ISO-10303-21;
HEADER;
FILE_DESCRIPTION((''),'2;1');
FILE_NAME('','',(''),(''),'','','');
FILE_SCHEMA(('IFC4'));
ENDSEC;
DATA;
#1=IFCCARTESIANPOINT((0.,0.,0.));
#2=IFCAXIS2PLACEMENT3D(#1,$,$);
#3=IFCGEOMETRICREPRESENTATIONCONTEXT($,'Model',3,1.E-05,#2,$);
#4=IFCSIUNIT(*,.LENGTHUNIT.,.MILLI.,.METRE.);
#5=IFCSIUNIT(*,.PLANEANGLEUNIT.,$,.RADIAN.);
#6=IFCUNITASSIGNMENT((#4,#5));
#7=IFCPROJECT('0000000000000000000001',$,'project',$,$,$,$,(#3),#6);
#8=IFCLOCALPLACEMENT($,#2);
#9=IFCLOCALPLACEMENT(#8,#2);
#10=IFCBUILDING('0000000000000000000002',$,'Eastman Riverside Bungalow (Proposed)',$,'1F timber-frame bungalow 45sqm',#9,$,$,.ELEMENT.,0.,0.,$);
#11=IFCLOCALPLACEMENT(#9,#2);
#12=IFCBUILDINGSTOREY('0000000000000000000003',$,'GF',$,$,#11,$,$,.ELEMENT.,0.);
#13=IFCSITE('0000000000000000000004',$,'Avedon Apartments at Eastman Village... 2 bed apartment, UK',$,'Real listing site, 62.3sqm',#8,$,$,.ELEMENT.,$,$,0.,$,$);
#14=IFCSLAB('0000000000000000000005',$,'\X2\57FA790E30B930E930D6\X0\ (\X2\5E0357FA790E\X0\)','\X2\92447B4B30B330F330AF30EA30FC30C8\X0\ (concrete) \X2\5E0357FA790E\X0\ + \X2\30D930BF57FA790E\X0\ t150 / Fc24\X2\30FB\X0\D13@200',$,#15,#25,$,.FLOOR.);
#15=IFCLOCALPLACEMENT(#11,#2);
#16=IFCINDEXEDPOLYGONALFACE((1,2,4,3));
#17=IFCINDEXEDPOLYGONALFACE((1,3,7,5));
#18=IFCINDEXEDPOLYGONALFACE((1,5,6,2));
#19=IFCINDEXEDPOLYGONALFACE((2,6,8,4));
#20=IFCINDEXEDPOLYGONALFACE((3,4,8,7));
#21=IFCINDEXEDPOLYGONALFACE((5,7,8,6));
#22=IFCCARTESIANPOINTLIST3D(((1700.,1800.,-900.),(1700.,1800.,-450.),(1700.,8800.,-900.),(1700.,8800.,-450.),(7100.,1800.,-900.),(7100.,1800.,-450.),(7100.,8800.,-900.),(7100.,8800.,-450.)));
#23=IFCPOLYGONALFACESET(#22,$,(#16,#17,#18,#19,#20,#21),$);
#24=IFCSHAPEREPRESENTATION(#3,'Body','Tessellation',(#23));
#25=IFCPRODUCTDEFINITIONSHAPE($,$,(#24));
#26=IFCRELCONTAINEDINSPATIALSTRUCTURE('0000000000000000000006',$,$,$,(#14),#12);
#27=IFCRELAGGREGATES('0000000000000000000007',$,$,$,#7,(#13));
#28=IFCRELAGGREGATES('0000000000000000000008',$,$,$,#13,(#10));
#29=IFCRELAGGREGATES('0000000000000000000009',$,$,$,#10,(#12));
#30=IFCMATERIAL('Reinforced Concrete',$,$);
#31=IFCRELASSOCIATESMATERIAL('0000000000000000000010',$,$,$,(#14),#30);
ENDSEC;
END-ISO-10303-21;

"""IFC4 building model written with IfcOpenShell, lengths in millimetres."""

from ifc_helpers import new_model, si_unit, frame, frame_2d, origin, place, context, project, spatial, rectangle, extrude, material, element, save


model = new_model("IFC4")

# Units and contexts
model_context = context("Model", 3, precision=1e-05, world=origin())
ifc_project = project(units=[si_unit("LENGTHUNIT", "METRE", prefix="MILLI"), si_unit("PLANEANGLEUNIT", "RADIAN")], contexts=[model_context])

# Site, building, storey
site_placement = place(None, origin())
site = spatial("IfcSite", under=ifc_project, at=site_placement, Name="Avedon Apartments at Eastman Village... 2 bed apartment, UK", ObjectType="Real listing site, 62.3sqm", CompositionType="ELEMENT", RefElevation=0.0)
building_placement = place(site_placement, origin())
building = spatial("IfcBuilding", under=site, at=building_placement, Name="Eastman Riverside Bungalow (Proposed)", ObjectType="1F timber-frame bungalow 45sqm", CompositionType="ELEMENT", ElevationOfRefHeight=0.0, ElevationOfTerrain=0.0)
storey_placement = place(building_placement, origin())
storey = spatial("IfcBuildingStorey", under=building, at=storey_placement, Name="GF", CompositionType="ELEMENT", Elevation=0.0)

# Slab
ifc_material_1 = material(Name="Reinforced Concrete")
slab_1_placement = place(storey_placement, frame((850.0, 900.0, -450.0)))
element("IfcSlab", 1, at=slab_1_placement, inside=storey, material=ifc_material_1, Name="基礎スラブ (布基礎)", Description="鉄筋コンクリート (concrete) 布基礎 + ベタ基礎 t150 / Fc24・D13@200", PredefinedType="FLOOR", context=model_context, shape_type="SweptSolid", body=[
    extrude(rectangle(XDim=5400.0, YDim=7000.0, at=frame_2d((2700.0, 3500.0))), frame((850.0, 900.0, -450.0)), (0.0, 0.0, 1.0), 450.0),
])

save(model, "model.ifc")
